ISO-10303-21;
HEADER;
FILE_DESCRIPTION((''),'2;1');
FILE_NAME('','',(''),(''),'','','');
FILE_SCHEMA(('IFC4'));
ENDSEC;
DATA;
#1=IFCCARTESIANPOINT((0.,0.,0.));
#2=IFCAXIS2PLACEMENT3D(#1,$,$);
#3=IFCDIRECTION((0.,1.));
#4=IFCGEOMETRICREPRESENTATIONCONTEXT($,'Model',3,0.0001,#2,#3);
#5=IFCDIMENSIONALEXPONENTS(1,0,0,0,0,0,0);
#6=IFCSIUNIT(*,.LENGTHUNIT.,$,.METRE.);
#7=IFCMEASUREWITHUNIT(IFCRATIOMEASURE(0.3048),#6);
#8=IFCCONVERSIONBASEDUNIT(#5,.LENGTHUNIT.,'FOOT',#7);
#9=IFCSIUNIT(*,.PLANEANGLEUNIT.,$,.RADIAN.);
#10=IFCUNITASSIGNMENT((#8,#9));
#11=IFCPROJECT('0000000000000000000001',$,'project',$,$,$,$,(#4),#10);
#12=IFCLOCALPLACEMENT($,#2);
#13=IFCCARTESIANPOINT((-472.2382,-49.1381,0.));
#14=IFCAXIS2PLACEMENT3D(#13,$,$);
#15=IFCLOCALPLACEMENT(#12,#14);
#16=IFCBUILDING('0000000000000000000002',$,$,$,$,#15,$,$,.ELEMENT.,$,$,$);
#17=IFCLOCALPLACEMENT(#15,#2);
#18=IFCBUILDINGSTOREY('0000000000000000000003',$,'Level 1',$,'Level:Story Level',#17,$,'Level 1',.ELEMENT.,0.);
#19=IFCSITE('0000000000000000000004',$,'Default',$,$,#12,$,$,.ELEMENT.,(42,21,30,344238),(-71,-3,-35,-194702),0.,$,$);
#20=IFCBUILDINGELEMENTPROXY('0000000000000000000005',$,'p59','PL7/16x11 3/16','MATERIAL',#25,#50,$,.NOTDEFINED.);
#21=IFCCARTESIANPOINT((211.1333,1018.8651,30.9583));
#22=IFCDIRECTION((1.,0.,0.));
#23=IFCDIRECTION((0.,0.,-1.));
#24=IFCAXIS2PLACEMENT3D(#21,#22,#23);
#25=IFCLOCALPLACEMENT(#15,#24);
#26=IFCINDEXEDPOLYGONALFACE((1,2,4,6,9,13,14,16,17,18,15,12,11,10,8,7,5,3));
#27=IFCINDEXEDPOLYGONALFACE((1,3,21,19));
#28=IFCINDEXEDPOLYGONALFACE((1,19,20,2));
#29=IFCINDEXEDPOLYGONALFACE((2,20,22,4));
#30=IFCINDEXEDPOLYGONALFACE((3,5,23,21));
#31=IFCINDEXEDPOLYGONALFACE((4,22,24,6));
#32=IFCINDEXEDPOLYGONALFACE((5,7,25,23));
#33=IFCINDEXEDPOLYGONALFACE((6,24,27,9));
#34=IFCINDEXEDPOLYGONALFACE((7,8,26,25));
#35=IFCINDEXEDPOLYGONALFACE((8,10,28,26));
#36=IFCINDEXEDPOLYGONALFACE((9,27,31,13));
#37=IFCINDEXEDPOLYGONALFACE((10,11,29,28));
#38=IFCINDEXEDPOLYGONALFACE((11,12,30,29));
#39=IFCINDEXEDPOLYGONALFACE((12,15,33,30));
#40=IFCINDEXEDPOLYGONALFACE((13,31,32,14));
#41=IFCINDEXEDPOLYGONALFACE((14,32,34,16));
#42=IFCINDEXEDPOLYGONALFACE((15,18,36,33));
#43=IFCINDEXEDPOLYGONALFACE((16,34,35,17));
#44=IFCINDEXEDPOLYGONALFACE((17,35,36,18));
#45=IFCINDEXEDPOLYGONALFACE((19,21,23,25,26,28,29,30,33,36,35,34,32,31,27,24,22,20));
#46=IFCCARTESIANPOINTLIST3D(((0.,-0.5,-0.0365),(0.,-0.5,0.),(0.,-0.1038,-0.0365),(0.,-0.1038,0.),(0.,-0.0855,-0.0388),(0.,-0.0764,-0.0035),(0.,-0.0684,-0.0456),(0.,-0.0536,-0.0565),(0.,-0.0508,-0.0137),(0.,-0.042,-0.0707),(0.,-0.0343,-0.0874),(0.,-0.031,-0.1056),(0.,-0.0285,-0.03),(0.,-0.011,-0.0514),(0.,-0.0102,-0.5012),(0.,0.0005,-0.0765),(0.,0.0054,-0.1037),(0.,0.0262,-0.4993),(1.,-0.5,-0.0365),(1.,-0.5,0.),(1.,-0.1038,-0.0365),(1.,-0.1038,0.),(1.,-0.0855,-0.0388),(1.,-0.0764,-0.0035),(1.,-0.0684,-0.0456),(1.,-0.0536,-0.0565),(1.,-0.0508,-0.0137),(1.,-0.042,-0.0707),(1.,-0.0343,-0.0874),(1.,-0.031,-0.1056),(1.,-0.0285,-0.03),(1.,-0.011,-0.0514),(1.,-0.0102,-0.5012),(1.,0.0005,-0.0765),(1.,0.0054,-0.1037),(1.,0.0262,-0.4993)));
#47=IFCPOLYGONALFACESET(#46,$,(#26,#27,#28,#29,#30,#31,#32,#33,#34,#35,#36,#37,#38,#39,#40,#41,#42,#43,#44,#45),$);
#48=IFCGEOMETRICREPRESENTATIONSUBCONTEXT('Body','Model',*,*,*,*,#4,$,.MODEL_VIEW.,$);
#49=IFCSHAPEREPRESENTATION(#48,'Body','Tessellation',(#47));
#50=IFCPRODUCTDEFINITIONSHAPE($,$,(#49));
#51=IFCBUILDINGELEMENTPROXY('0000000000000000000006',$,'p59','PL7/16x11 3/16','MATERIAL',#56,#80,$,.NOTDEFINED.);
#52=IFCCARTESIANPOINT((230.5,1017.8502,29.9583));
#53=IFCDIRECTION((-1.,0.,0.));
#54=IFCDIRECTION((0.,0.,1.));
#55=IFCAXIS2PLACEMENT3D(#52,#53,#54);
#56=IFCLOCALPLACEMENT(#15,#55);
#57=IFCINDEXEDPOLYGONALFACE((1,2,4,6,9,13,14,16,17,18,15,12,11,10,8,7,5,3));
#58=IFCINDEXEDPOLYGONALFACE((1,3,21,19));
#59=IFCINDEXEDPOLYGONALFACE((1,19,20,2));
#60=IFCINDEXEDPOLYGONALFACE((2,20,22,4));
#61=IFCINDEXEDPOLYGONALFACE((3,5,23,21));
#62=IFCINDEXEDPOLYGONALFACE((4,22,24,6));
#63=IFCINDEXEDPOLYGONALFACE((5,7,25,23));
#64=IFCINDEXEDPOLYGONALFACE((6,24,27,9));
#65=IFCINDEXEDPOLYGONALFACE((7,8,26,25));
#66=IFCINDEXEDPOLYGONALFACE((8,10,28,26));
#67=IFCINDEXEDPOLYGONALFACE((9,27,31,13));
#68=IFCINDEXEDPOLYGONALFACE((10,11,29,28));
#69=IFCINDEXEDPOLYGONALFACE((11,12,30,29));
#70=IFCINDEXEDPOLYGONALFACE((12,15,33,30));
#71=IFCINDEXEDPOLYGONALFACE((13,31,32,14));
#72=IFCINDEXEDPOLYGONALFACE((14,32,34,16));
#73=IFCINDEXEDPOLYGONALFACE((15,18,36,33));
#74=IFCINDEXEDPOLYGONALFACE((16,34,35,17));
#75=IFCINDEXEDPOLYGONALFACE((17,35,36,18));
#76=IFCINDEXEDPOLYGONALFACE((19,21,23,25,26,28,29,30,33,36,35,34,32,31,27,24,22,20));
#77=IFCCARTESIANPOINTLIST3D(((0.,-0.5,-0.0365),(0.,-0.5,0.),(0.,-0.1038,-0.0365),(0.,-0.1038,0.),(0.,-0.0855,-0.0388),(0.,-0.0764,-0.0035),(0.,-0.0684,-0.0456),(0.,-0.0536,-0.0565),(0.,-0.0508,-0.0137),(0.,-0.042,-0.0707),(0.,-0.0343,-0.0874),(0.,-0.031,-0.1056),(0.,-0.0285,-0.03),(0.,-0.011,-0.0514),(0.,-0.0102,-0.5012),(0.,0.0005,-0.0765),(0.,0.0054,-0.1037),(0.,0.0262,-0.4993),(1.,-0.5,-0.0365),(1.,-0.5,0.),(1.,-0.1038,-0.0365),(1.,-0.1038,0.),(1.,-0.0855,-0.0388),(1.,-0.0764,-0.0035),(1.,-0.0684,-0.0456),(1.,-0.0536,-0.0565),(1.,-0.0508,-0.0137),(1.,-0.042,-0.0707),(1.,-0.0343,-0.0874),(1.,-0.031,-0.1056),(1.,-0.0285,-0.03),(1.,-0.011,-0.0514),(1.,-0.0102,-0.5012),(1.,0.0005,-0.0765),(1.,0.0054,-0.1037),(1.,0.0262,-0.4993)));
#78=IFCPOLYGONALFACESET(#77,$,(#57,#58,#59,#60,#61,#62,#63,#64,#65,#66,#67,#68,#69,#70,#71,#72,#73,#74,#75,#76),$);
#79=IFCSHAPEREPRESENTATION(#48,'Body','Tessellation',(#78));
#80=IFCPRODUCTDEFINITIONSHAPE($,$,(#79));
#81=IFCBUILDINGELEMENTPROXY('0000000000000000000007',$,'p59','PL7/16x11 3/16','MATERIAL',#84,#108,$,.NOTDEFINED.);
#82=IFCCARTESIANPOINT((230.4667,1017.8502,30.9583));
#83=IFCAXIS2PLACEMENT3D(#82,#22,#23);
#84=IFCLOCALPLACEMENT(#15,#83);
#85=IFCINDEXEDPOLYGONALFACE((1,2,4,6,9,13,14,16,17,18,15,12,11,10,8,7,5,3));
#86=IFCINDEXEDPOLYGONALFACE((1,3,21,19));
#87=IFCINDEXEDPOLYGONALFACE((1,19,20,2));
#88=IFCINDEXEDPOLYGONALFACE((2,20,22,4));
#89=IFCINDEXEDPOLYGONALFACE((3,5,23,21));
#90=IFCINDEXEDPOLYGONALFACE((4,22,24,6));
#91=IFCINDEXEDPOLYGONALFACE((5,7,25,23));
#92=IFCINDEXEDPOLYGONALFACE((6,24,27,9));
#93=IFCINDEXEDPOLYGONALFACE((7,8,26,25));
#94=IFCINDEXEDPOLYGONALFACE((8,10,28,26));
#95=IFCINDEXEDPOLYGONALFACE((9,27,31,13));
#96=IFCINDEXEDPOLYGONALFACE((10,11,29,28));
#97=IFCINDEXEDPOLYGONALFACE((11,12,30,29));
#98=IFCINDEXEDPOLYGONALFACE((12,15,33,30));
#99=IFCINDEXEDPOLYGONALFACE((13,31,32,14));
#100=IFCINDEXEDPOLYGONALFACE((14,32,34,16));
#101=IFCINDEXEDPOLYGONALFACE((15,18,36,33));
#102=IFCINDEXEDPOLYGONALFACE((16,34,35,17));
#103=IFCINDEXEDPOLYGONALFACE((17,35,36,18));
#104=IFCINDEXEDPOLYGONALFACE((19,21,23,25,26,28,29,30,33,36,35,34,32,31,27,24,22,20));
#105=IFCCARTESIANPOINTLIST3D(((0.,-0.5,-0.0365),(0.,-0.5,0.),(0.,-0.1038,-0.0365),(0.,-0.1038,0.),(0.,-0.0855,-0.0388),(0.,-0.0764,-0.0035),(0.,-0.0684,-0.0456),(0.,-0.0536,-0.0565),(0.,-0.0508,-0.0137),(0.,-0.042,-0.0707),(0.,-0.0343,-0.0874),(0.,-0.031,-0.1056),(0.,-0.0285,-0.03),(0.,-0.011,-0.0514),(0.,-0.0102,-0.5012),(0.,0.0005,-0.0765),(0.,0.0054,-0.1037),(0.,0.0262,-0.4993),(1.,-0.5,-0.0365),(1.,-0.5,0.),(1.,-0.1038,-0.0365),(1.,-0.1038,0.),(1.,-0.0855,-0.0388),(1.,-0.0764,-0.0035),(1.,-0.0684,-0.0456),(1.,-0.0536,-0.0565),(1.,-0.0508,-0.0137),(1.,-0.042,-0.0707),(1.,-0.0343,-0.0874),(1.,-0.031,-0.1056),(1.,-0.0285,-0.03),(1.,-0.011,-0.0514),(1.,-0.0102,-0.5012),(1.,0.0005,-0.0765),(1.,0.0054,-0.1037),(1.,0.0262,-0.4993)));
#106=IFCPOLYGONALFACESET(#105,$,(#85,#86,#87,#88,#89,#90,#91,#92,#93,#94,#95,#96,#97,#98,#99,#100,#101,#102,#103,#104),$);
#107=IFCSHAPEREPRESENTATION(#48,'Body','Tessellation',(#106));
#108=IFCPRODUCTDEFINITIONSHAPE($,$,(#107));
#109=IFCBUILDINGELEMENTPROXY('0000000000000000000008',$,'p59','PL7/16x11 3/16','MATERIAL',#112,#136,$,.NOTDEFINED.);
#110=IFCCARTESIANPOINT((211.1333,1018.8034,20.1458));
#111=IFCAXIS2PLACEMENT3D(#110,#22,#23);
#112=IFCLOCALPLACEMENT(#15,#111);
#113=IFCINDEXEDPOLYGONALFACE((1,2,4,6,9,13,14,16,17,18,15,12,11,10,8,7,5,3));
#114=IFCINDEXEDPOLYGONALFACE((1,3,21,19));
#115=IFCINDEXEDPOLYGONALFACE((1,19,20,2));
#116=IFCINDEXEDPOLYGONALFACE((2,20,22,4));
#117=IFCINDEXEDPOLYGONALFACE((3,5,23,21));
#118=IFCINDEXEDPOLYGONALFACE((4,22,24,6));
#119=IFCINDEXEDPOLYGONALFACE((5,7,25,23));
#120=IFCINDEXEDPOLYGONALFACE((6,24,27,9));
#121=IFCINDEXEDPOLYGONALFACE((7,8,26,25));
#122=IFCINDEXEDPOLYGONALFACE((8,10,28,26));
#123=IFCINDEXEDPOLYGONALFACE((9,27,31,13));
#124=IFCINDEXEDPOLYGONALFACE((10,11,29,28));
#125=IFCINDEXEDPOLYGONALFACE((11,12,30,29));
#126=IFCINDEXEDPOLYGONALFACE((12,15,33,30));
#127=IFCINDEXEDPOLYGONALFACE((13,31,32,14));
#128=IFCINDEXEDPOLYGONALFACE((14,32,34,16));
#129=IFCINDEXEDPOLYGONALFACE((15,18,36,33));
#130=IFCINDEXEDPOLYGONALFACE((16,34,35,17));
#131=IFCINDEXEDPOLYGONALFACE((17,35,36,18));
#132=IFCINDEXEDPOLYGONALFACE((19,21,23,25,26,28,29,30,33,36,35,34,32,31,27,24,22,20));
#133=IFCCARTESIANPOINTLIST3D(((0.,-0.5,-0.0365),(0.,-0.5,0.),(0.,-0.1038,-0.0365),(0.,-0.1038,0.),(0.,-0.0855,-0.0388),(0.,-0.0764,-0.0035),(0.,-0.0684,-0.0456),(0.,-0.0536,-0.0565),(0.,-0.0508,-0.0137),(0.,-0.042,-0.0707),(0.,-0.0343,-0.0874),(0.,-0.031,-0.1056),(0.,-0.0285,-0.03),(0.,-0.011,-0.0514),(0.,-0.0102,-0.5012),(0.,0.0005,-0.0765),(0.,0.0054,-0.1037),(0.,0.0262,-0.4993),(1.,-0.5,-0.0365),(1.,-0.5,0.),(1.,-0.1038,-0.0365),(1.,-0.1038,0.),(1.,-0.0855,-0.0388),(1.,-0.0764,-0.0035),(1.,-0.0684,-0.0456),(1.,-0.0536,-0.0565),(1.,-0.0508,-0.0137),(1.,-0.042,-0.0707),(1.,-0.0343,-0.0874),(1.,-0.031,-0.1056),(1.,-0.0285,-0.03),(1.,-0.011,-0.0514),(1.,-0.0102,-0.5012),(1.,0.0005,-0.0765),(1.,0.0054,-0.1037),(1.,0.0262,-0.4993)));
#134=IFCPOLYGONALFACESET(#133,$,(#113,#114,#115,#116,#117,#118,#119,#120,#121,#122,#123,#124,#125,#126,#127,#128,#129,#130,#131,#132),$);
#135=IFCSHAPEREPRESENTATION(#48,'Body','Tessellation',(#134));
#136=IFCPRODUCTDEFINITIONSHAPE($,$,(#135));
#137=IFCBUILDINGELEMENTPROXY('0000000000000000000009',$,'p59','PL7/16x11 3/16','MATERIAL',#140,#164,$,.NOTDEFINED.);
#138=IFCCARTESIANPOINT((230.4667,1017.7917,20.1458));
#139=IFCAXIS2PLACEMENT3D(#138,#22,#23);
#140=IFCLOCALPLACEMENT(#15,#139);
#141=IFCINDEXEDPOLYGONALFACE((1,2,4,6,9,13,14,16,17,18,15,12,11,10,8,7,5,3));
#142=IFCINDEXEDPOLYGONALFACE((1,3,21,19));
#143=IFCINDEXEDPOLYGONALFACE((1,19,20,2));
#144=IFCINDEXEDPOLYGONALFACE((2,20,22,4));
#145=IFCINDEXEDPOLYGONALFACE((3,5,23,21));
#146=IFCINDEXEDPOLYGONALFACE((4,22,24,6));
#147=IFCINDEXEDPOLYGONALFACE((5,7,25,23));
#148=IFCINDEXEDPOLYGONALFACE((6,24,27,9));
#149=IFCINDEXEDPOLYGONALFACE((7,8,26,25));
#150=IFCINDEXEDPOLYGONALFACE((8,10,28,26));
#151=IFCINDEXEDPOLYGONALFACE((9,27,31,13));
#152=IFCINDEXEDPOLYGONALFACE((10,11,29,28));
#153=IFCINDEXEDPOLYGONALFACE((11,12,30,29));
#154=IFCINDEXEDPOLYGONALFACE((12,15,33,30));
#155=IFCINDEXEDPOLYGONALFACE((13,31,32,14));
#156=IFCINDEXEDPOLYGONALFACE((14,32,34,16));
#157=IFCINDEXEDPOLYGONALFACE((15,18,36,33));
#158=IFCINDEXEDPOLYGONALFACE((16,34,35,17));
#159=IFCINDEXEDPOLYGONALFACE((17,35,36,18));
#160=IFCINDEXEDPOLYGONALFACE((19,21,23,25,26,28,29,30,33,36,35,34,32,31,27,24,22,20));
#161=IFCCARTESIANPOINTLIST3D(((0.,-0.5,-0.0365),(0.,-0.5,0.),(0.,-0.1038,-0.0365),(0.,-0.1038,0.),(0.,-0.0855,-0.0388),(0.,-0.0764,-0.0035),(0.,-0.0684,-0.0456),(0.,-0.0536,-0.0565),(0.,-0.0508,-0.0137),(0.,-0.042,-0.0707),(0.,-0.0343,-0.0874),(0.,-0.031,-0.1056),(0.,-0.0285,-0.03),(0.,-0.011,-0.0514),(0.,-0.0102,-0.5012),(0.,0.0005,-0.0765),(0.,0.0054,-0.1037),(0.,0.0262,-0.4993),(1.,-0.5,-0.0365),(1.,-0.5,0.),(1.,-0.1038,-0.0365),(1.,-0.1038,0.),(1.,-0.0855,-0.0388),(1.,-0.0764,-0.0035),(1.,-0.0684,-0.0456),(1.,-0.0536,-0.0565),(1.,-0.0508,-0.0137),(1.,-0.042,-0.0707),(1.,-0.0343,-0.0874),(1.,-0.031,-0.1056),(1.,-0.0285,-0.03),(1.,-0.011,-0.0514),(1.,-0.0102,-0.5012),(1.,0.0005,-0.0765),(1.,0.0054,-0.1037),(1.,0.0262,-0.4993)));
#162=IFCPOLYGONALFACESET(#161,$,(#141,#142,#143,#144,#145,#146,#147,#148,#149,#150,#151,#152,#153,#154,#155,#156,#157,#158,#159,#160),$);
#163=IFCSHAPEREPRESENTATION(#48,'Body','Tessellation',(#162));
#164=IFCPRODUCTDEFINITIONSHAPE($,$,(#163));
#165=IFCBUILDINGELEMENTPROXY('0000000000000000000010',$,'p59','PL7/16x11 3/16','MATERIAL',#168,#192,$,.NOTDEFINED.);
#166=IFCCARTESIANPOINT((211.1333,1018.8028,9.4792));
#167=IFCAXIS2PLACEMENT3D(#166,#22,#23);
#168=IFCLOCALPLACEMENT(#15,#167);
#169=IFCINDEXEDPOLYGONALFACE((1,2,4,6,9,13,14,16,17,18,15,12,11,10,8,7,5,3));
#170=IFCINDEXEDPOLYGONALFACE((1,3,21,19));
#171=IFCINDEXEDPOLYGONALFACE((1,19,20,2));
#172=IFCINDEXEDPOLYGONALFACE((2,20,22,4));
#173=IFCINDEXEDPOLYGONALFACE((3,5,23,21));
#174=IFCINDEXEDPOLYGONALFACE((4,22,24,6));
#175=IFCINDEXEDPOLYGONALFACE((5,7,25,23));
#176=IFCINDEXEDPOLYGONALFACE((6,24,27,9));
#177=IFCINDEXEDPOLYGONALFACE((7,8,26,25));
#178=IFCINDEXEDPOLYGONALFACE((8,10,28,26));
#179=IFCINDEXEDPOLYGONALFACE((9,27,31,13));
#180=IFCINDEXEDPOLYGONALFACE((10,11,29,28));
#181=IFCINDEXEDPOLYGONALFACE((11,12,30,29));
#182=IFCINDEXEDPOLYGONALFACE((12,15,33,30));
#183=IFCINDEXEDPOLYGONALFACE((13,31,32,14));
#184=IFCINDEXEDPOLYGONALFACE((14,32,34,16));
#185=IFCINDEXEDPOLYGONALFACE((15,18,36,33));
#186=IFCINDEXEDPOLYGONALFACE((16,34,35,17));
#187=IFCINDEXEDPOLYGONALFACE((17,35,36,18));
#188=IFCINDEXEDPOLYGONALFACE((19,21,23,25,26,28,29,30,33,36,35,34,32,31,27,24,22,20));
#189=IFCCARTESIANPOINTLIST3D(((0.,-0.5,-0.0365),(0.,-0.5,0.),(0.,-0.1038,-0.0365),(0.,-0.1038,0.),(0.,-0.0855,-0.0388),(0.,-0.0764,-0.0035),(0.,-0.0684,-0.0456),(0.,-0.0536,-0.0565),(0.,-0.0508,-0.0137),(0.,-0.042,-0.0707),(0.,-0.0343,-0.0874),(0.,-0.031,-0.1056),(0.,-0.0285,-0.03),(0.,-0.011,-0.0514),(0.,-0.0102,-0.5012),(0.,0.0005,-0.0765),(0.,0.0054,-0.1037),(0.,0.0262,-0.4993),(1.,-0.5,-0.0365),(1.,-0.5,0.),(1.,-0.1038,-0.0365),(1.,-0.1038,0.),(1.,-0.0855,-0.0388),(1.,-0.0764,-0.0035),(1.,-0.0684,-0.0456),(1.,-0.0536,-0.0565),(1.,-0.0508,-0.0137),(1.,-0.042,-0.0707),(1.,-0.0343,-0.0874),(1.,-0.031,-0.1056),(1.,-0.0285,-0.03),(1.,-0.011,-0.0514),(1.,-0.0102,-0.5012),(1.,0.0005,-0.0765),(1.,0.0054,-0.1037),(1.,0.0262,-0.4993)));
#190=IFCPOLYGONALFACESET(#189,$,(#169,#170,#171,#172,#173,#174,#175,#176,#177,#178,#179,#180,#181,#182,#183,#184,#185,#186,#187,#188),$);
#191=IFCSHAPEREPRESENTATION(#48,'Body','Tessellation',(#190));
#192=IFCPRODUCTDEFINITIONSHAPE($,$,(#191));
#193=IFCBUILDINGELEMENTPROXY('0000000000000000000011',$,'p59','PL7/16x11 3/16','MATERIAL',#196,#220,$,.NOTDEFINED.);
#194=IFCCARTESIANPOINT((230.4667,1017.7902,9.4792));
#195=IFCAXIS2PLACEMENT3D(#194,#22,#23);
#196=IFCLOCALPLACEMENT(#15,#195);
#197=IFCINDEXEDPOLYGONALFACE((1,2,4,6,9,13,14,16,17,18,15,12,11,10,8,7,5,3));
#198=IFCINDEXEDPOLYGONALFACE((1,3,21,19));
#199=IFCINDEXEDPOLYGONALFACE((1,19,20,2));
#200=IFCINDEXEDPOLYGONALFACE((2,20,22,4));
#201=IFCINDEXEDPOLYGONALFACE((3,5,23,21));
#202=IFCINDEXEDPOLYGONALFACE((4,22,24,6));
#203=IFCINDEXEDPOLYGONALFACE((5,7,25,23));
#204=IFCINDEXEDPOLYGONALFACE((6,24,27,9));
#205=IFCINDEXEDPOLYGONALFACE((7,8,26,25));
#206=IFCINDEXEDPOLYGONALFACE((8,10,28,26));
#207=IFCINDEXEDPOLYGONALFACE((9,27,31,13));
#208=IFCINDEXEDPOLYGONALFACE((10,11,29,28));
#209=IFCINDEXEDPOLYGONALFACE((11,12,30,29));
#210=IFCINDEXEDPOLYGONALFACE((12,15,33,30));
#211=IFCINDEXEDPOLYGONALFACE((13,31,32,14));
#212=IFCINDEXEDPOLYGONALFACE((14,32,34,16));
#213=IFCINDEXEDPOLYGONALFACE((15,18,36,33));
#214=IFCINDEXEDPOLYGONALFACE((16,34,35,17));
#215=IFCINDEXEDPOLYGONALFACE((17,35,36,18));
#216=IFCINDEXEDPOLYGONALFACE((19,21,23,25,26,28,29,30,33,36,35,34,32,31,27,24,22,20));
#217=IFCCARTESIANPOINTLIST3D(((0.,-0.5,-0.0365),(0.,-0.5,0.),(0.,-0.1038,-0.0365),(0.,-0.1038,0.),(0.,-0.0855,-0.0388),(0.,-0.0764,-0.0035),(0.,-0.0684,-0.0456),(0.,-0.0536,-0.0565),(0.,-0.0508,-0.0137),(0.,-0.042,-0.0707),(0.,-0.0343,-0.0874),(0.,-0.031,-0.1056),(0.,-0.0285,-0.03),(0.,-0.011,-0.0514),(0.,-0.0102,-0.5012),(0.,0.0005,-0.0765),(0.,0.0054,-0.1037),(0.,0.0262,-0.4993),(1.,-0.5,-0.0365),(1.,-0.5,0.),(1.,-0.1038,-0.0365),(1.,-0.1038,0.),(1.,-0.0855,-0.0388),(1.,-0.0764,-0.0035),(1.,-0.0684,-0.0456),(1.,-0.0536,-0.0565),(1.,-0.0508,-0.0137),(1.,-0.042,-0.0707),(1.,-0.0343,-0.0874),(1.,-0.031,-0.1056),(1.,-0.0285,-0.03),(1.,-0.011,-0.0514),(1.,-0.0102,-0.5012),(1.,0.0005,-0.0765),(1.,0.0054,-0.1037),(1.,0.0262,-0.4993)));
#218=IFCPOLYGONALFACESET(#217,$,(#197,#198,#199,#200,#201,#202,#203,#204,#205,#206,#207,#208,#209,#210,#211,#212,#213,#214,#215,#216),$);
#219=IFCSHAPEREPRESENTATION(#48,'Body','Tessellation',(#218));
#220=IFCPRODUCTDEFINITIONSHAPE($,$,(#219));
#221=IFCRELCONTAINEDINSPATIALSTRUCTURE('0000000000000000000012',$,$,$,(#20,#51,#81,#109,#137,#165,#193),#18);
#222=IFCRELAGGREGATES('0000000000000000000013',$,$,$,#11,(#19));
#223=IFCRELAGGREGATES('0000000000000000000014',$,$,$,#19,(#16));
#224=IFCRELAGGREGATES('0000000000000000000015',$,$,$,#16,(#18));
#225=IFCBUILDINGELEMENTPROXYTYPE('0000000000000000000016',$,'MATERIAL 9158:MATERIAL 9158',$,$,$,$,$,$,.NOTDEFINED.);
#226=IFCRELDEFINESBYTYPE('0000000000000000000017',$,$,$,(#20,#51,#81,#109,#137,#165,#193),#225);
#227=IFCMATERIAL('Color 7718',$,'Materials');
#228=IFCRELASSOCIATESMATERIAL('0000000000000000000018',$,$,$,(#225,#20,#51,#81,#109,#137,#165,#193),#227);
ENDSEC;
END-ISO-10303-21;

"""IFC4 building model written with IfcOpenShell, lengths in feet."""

from ifc_helpers import new_model, entity, si_unit, converted_unit, direction, frame, origin, place, context, subcontext, project, spatial, polyline, outline, extrude, source, transform, mapped, material, type_object, type_shapes, element, save


model = new_model("IFC4")

# Units and contexts
model_context = context("Model", 3, precision=0.0001, world=origin(), true_north=direction((0.0, 1.0)))
body_context = subcontext(model_context, "Body", "Model", "MODEL_VIEW")
ifc_project = project(units=[converted_unit("LENGTHUNIT", "FOOT", entity("IfcRatioMeasure", 0.3048), si_unit("LENGTHUNIT", "METRE"), dimensions=[1, 0, 0, 0, 0, 0, 0]), si_unit("PLANEANGLEUNIT", "RADIAN")], contexts=[model_context])

# Site, building, storey
site_placement = place(None, origin())
site = spatial("IfcSite", under=ifc_project, at=site_placement, Name="Default", CompositionType="ELEMENT", RefLatitude=(42, 21, 30, 344238), RefLongitude=(-71, -3, -35, -194702), RefElevation=0.0)
building_placement = place(site_placement, frame((-472.2382, -49.1381, 0.0)))
building = spatial("IfcBuilding", under=site, at=building_placement, CompositionType="ELEMENT")
storey_placement = place(building_placement, origin())
storey = spatial("IfcBuildingStorey", under=building, at=storey_placement, Name="Level 1", ObjectType="Level:Story Level", LongName="Level 1", CompositionType="ELEMENT", Elevation=0.0)

# Building element proxies
ifc_material_1 = material(Name="Color 7718", Category="Materials")
building_element_proxy_type_1 = type_object("IfcBuildingElementProxyType", Name="MATERIAL 9158:MATERIAL 9158", PredefinedType="NOTDEFINED", material=ifc_material_1)
shared_shape_1 = source(origin(), body_context, "Body", "SweptSolid", [
    extrude(outline(polyline([(0.0112, -0.0976), (0.4074, -0.0976), (0.4074, -0.0611), (0.0112, -0.0611), (-0.0071, -0.0588), (-0.0242, -0.052), (-0.039, -0.0411), (-0.0507, -0.0269), (-0.0584, -0.0102), (-0.0616, 0.008), (-0.0824, 0.4036), (-0.1188, 0.4017), (-0.0981, 0.006), (-0.0931, -0.0211), (-0.0816, -0.0462), (-0.0641, -0.0676), (-0.0419, -0.0839), (-0.0162, -0.0941), (0.0112, -0.0976)])), frame((0.0, -0.0926, -0.0976), z_axis=(1.0, 0.0, 0.0), x_axis=(0.0, -1.0, 0.0)), (0.0, 0.0, 1.0), 1.0),
])
type_shapes(building_element_proxy_type_1, [shared_shape_1])
for number, where, z_axis, x_axis, name in (
    (1, (211.1333, 1018.8651, 30.9583), (1.0, 0.0, 0.0), (0.0, 0.0, -1.0), "p59"),
    (2, (230.5, 1017.8502, 29.9583), (-1.0, 0.0, 0.0), (0.0, 0.0, 1.0), "p59"),
    (3, (230.4667, 1017.8502, 30.9583), (1.0, 0.0, 0.0), (0.0, 0.0, -1.0), "p59"),
    (4, (211.1333, 1018.8034, 20.1458), (1.0, 0.0, 0.0), (0.0, 0.0, -1.0), "p59"),
    (5, (230.4667, 1017.7917, 20.1458), (1.0, 0.0, 0.0), (0.0, 0.0, -1.0), "p59"),
    (6, (211.1333, 1018.8028, 9.4792), (1.0, 0.0, 0.0), (0.0, 0.0, -1.0), "p59"),
    (7, (230.4667, 1017.7902, 9.4792), (1.0, 0.0, 0.0), (0.0, 0.0, -1.0), "p59"),
):
    element("IfcBuildingElementProxy", number, at=place(building_placement, frame(where, z_axis=z_axis, x_axis=x_axis)), inside=storey, type_object=building_element_proxy_type_1, material=ifc_material_1, Name=name, Description="PL7/16x11 3/16", ObjectType="MATERIAL", PredefinedType="NOTDEFINED", context=body_context, shape_type="MappedRepresentation", body=[
        mapped(shared_shape_1, transform((0.0, 0.0, 0.0), scale=1.0)),
    ])

save(model, "model.ifc")
